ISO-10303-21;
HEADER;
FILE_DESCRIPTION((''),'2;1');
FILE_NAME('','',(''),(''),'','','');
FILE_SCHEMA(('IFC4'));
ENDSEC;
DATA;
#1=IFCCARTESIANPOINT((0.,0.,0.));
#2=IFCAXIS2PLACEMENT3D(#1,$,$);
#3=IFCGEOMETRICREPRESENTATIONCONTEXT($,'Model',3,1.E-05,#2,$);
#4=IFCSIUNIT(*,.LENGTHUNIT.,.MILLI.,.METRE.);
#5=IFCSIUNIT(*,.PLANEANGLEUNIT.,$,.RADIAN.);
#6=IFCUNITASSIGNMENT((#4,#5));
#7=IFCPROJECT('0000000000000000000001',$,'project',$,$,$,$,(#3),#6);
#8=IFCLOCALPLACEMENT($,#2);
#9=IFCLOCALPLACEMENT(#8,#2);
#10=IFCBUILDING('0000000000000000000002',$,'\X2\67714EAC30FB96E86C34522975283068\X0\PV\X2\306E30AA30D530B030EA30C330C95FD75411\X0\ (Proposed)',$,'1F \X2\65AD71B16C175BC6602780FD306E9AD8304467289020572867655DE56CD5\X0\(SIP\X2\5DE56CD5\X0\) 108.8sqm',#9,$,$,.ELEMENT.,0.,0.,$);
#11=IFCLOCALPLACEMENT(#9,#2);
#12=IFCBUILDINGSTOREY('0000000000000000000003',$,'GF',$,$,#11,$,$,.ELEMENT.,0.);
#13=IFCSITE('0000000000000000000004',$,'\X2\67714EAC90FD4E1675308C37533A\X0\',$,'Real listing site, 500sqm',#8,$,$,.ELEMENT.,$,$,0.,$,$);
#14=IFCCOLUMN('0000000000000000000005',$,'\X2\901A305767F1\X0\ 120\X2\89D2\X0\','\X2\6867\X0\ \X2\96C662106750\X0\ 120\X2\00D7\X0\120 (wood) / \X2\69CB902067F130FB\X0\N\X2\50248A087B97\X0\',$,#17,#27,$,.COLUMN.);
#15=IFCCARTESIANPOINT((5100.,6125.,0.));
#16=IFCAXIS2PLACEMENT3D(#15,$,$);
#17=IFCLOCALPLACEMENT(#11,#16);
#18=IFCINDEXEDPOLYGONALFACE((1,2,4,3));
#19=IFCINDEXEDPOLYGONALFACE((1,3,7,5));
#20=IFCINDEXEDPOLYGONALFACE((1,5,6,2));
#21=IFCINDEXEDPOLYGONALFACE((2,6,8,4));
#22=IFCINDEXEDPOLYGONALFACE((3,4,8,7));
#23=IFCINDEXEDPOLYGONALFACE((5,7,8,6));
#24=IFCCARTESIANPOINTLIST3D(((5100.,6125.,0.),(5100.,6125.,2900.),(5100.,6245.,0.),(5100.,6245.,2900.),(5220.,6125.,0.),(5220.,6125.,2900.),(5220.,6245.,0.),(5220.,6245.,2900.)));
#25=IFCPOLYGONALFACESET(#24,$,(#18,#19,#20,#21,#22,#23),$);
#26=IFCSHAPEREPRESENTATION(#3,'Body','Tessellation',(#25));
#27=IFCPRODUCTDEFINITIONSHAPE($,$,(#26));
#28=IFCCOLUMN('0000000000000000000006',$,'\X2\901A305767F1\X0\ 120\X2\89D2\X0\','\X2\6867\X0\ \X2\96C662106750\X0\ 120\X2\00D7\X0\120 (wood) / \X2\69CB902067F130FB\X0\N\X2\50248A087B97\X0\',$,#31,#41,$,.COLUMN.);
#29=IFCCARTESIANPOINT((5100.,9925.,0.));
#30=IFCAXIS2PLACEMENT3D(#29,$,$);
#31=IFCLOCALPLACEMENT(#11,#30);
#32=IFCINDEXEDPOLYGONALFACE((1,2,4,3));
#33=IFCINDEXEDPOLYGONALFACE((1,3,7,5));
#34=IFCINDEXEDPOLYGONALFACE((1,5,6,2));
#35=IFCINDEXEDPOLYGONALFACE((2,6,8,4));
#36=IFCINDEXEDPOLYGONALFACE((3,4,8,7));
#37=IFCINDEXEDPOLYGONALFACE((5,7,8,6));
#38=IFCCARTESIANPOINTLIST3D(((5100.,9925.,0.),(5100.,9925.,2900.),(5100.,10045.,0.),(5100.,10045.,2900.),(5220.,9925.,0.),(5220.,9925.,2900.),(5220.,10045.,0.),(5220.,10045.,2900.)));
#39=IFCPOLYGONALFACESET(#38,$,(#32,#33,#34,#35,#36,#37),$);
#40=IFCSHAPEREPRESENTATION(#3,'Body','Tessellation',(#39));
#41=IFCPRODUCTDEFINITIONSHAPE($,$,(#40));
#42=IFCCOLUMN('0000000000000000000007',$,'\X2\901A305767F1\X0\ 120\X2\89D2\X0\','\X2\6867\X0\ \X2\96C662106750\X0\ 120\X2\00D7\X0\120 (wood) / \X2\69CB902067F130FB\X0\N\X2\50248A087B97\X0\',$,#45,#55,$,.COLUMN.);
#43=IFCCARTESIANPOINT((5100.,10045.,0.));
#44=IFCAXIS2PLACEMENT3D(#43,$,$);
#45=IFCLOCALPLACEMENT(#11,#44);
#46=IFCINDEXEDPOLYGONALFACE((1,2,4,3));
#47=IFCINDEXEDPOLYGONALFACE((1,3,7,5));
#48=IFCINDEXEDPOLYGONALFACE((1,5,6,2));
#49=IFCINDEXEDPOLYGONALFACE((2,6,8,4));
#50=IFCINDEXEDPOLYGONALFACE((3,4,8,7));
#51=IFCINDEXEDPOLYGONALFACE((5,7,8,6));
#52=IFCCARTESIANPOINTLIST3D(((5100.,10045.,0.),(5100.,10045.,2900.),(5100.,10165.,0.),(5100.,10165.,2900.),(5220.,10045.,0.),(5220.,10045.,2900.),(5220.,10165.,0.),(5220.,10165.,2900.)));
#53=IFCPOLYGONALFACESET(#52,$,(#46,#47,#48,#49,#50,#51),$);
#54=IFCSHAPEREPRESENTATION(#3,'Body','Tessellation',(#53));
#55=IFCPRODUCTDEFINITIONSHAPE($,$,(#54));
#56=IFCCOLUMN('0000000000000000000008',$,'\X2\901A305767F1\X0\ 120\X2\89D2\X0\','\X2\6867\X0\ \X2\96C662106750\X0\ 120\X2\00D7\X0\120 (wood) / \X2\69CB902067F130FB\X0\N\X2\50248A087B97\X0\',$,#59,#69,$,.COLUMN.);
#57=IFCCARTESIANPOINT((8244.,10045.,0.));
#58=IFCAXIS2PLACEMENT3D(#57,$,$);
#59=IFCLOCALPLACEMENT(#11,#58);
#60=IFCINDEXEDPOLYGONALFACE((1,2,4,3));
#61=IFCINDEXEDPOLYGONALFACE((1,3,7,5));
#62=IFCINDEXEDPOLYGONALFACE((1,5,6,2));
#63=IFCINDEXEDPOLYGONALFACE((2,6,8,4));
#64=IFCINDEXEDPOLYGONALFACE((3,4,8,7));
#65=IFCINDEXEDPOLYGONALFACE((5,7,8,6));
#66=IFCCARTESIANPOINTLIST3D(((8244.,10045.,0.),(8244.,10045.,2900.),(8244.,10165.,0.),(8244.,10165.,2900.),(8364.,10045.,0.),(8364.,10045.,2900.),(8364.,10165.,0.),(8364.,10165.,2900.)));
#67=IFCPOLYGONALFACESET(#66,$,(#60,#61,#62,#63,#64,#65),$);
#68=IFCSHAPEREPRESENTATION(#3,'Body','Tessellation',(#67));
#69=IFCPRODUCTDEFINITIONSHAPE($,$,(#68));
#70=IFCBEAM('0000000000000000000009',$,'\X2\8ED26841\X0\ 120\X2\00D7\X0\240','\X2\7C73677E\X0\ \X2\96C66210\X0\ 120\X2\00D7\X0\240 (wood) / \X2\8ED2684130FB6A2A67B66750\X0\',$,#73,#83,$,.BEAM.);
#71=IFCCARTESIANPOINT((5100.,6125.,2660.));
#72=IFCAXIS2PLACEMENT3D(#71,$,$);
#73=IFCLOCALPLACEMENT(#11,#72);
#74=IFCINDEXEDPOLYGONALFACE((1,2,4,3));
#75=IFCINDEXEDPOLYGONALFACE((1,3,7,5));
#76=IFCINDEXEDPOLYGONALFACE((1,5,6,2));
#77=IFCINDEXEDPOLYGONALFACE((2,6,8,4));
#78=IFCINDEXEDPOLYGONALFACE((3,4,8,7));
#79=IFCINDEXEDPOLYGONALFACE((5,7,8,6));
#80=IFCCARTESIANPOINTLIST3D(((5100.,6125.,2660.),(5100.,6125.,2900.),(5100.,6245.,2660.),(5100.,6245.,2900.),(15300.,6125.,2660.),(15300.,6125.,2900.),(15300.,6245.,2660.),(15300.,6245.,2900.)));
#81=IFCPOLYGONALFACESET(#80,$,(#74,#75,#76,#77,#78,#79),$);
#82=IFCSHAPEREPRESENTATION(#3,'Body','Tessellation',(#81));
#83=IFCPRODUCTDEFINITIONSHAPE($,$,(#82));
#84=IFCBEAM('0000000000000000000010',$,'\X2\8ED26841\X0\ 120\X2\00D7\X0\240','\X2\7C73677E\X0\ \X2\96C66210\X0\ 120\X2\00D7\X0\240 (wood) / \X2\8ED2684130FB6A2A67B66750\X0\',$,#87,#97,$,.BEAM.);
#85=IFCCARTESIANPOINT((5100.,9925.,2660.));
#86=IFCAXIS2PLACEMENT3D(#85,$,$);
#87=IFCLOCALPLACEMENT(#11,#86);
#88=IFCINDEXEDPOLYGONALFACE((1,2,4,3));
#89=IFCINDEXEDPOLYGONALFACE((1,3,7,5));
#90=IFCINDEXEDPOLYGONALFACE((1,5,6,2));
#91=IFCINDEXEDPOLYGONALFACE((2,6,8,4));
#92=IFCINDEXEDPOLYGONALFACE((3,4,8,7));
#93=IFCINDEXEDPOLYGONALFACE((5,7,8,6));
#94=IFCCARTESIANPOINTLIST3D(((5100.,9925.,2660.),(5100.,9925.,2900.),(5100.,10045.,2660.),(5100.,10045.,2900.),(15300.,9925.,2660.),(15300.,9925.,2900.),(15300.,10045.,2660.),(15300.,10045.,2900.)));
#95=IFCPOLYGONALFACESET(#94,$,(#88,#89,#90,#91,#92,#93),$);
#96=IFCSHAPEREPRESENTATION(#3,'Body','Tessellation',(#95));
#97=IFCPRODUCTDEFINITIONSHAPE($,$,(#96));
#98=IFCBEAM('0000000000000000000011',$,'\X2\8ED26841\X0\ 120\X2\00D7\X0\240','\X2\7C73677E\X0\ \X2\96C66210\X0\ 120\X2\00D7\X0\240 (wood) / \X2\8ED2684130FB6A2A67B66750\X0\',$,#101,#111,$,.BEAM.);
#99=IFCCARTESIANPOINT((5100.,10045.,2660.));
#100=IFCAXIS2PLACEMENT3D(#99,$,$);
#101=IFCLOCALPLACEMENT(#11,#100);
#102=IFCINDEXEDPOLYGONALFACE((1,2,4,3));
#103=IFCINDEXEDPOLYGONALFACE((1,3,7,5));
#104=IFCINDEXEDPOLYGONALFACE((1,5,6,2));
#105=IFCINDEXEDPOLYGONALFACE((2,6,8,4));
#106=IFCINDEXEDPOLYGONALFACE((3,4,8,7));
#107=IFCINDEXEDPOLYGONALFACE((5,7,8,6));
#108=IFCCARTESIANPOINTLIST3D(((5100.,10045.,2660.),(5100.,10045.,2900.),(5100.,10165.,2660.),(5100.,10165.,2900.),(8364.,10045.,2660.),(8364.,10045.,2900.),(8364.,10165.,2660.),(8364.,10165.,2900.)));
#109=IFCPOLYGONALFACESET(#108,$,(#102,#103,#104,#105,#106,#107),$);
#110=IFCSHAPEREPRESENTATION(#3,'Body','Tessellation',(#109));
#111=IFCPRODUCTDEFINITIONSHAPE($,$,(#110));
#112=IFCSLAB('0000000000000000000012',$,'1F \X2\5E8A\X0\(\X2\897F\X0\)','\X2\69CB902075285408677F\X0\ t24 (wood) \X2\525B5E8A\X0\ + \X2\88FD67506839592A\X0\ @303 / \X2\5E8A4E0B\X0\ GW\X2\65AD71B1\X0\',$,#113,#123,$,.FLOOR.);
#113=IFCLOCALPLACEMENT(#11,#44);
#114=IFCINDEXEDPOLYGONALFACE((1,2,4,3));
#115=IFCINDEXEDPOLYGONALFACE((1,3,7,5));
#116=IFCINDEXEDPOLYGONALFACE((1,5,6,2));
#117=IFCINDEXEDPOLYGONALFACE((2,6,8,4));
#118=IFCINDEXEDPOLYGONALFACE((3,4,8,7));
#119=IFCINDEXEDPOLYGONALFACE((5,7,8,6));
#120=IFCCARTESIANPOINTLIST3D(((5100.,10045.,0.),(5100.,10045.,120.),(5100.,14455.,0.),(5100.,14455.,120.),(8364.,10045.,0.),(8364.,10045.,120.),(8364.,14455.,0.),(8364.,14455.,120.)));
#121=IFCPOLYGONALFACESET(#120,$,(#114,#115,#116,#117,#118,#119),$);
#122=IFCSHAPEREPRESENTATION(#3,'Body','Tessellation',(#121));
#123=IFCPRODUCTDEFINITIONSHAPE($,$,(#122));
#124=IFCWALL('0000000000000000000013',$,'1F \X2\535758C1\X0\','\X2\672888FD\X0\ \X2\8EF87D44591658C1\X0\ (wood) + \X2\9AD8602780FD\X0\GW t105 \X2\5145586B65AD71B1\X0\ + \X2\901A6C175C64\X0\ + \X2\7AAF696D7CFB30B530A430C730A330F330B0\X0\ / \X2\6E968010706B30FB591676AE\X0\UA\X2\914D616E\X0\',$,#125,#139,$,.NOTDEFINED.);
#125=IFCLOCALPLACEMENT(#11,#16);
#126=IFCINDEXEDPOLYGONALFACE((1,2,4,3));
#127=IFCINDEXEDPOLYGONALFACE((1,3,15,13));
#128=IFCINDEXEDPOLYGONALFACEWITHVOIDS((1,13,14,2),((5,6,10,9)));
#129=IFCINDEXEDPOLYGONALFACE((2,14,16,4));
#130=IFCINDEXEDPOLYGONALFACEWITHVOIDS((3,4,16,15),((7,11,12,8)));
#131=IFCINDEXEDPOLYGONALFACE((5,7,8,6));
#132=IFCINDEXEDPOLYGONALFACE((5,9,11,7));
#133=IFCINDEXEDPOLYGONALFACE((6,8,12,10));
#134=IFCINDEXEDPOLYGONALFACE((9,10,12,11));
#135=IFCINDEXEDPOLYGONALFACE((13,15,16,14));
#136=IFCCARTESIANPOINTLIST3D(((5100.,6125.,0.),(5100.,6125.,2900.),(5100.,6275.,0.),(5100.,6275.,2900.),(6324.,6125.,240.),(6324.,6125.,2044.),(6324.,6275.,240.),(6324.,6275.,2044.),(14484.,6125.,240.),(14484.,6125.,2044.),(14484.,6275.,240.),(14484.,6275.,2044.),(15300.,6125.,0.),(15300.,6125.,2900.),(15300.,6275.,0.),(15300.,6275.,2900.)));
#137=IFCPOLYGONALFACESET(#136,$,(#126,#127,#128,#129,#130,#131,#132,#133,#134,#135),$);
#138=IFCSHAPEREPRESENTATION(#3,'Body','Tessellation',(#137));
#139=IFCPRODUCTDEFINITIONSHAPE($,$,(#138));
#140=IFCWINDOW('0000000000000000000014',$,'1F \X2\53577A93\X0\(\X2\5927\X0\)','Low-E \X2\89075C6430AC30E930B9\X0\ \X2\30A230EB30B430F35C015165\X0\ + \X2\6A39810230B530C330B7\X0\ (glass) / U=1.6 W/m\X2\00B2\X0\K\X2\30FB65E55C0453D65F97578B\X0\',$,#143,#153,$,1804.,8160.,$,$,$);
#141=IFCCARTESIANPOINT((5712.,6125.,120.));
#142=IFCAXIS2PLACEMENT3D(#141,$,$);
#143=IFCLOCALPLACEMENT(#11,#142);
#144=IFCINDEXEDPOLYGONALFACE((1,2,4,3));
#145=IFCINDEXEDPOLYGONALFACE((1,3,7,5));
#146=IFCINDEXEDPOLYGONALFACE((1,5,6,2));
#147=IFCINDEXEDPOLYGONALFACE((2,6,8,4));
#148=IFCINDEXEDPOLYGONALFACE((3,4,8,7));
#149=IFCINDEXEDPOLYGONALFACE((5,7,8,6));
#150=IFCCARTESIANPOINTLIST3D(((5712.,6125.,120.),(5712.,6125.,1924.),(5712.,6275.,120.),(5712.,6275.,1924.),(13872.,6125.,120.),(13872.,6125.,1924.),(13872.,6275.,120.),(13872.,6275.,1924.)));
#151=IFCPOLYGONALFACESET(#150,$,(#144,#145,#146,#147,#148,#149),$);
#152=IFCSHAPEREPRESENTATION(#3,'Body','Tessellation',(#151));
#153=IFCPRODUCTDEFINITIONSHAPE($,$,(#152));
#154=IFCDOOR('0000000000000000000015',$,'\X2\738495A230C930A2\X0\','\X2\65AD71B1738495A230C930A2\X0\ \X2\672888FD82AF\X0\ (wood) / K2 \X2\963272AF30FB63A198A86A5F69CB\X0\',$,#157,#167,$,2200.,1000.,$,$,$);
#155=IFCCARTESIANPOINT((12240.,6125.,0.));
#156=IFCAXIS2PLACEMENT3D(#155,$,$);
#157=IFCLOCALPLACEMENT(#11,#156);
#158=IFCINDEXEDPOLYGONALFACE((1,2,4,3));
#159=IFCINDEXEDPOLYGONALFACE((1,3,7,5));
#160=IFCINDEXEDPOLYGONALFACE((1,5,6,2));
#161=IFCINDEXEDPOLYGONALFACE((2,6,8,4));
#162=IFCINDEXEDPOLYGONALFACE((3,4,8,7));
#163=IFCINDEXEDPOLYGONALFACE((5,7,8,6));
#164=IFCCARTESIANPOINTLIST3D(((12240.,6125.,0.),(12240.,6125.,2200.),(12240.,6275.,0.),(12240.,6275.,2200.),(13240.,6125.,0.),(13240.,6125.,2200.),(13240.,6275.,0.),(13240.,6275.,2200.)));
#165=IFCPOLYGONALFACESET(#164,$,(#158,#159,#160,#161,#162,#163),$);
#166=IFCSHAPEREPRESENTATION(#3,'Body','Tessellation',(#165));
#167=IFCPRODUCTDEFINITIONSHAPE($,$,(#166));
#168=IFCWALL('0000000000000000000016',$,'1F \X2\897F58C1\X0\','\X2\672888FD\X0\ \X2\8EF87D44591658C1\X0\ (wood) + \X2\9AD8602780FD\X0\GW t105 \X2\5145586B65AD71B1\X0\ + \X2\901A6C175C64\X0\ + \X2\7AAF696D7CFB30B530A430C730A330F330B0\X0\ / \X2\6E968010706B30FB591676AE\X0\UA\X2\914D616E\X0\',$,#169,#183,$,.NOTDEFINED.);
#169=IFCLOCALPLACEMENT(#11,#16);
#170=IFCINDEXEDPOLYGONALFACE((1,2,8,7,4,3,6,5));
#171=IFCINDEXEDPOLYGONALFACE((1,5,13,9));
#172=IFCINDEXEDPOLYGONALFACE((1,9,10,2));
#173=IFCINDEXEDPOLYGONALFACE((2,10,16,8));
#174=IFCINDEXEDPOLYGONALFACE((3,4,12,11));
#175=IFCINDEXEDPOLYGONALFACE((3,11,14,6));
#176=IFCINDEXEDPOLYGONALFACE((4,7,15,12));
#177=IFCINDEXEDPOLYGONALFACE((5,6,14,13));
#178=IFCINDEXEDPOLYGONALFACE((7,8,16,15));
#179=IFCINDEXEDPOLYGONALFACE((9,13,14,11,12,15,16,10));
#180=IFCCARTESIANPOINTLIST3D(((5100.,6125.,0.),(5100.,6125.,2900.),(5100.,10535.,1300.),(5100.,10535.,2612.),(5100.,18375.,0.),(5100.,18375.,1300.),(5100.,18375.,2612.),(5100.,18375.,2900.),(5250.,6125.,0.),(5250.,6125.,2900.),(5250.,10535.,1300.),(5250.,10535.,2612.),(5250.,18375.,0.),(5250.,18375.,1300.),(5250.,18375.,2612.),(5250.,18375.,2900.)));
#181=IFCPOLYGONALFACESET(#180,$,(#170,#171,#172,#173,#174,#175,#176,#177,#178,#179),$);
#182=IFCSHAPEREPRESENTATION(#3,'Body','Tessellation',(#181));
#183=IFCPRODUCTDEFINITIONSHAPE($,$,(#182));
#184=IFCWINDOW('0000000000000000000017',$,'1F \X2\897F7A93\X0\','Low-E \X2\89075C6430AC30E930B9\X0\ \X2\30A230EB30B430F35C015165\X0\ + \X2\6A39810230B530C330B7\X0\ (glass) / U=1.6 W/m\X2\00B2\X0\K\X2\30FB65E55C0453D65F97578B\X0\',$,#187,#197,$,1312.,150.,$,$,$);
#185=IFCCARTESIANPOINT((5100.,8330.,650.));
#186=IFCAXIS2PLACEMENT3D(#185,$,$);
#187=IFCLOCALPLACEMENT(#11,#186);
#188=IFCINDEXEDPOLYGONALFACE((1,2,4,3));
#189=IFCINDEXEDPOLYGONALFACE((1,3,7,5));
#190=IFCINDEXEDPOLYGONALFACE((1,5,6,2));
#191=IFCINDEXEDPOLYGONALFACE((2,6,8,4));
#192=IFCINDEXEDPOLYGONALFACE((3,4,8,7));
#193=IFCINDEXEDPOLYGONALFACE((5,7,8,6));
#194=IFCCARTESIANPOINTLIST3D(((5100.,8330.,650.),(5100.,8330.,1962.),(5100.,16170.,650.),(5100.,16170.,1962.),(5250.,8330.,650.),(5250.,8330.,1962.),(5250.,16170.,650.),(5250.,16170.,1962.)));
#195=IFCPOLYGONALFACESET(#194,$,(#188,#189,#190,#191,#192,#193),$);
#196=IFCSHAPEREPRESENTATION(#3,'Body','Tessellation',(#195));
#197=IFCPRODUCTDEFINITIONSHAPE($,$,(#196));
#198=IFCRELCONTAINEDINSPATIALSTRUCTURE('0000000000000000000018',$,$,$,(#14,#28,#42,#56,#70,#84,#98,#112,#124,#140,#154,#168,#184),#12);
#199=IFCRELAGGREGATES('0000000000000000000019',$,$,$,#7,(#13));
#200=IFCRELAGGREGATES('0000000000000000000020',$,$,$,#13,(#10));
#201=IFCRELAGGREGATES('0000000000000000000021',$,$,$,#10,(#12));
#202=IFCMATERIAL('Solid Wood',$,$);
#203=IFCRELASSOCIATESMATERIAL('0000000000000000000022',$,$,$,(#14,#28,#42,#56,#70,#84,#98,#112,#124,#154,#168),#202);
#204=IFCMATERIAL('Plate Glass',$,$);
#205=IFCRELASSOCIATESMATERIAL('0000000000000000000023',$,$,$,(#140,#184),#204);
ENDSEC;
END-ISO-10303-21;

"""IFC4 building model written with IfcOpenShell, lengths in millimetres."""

from ifc_helpers import new_model, si_unit, frame, frame_2d, origin, place, context, project, spatial, rectangle, extrude, material, element, fill, save


model = new_model("IFC4")

# Units and contexts
model_context = context("Model", 3, precision=1e-05, world=origin())
ifc_project = project(units=[si_unit("LENGTHUNIT", "METRE", prefix="MILLI"), si_unit("PLANEANGLEUNIT", "RADIAN")], contexts=[model_context])

# Site, building, storey
site_placement = place(None, origin())
site = spatial("IfcSite", under=ifc_project, at=site_placement, Name="東京都世田谷区", ObjectType="Real listing site, 500sqm", CompositionType="ELEMENT", RefElevation=0.0)
building_placement = place(site_placement, origin())
building = spatial("IfcBuilding", under=site, at=building_placement, Name="東京・雨水利用とPVのオフグリッド志向 (Proposed)", ObjectType="1F 断熱気密性能の高い木造在来工法(SIP工法) 108.8sqm", CompositionType="ELEMENT", ElevationOfRefHeight=0.0, ElevationOfTerrain=0.0)
storey_placement = place(building_placement, origin())
storey = spatial("IfcBuildingStorey", under=building, at=storey_placement, Name="GF", CompositionType="ELEMENT", Elevation=0.0)

# Columns
ifc_material_1 = material(Name="Solid Wood")
column_1_placement = place(storey_placement, frame((5100.0, 6125.0, 0.0)))
element("IfcColumn", 1, at=column_1_placement, inside=storey, material=ifc_material_1, Name="通し柱 120角", Description="桧 集成材 120×120 (wood) / 構造柱・N値計算", PredefinedType="COLUMN", context=model_context, shape_type="SweptSolid", body=[
    extrude(rectangle(XDim=120.0, YDim=120.0, at=frame_2d((60.0, 60.0))), frame((5100.0, 6125.0, 0.0)), (0.0, 0.0, 1.0), 2900.0),
])
column_2_placement = place(storey_placement, frame((5100.0, 9925.0, 0.0)))
element("IfcColumn", 2, at=column_2_placement, inside=storey, material=ifc_material_1, Name="通し柱 120角", Description="桧 集成材 120×120 (wood) / 構造柱・N値計算", PredefinedType="COLUMN", context=model_context, shape_type="SweptSolid", body=[
    extrude(rectangle(XDim=120.0, YDim=120.0, at=frame_2d((60.0, 60.0))), frame((5100.0, 9925.0, 0.0)), (0.0, 0.0, 1.0), 2900.0),
])
column_3_placement = place(storey_placement, frame((5100.0, 10045.0, 0.0)))
element("IfcColumn", 3, at=column_3_placement, inside=storey, material=ifc_material_1, Name="通し柱 120角", Description="桧 集成材 120×120 (wood) / 構造柱・N値計算", PredefinedType="COLUMN", context=model_context, shape_type="SweptSolid", body=[
    extrude(rectangle(XDim=120.0, YDim=120.0, at=frame_2d((60.0, 60.0))), frame((5100.0, 10045.0, 0.0)), (0.0, 0.0, 1.0), 2900.0),
])
column_4_placement = place(storey_placement, frame((8244.0, 10045.0, 0.0)))
element("IfcColumn", 4, at=column_4_placement, inside=storey, material=ifc_material_1, Name="通し柱 120角", Description="桧 集成材 120×120 (wood) / 構造柱・N値計算", PredefinedType="COLUMN", context=model_context, shape_type="SweptSolid", body=[
    extrude(rectangle(XDim=120.0, YDim=120.0, at=frame_2d((60.0, 60.0))), frame((8244.0, 10045.0, 0.0)), (0.0, 0.0, 1.0), 2900.0),
])

# Beams
beam_1_placement = place(storey_placement, frame((5100.0, 6125.0, 2660.0)))
element("IfcBeam", 5, at=beam_1_placement, inside=storey, material=ifc_material_1, Name="軒桁 120×240", Description="米松 集成 120×240 (wood) / 軒桁・横架材", PredefinedType="BEAM", context=model_context, shape_type="SweptSolid", body=[
    extrude(rectangle(XDim=10200.0, YDim=120.0, at=frame_2d((5100.0, 60.0))), frame((5100.0, 6125.0, 2660.0)), (0.0, 0.0, 1.0), 240.0),
])
beam_2_placement = place(storey_placement, frame((5100.0, 9925.0, 2660.0)))
element("IfcBeam", 6, at=beam_2_placement, inside=storey, material=ifc_material_1, Name="軒桁 120×240", Description="米松 集成 120×240 (wood) / 軒桁・横架材", PredefinedType="BEAM", context=model_context, shape_type="SweptSolid", body=[
    extrude(rectangle(XDim=10200.0, YDim=120.0, at=frame_2d((5100.0, 60.0))), frame((5100.0, 9925.0, 2660.0)), (0.0, 0.0, 1.0), 240.0),
])
beam_3_placement = place(storey_placement, frame((5100.0, 10045.0, 2660.0)))
element("IfcBeam", 7, at=beam_3_placement, inside=storey, material=ifc_material_1, Name="軒桁 120×240", Description="米松 集成 120×240 (wood) / 軒桁・横架材", PredefinedType="BEAM", context=model_context, shape_type="SweptSolid", body=[
    extrude(rectangle(XDim=3264.0, YDim=120.0, at=frame_2d((1632.0, 60.0))), frame((5100.0, 10045.0, 2660.0)), (0.0, 0.0, 1.0), 240.0),
])

# Slab
slab_1_placement = place(storey_placement, frame((5100.0, 10045.0, 0.0)))
element("IfcSlab", 8, at=slab_1_placement, inside=storey, material=ifc_material_1, Name="1F 床(西)", Description="構造用合板 t24 (wood) 剛床 + 製材根太 @303 / 床下 GW断熱", PredefinedType="FLOOR", context=model_context, shape_type="SweptSolid", body=[
    extrude(rectangle(XDim=3264.0, YDim=4410.0, at=frame_2d((1632.0, 2205.0))), frame((5100.0, 10045.0, 0.0)), (0.0, 0.0, 1.0), 120.0),
])

# Wall, openings, window, door
wall_1_placement = place(storey_placement, frame((5100.0, 6125.0, 0.0)))
wall_1 = element("IfcWall", 9, at=wall_1_placement, inside=storey, material=ifc_material_1, Name="1F 南壁", Description="木製 軸組外壁 (wood) + 高性能GW t105 充填断熱 + 通気層 + 窯業系サイディング / 準耐火・外皮UA配慮", PredefinedType="NOTDEFINED", context=model_context, shape_type="SweptSolid", body=[
    extrude(rectangle(XDim=10200.0, YDim=150.0, at=frame_2d((5100.0, 75.0))), frame((5100.0, 6125.0, 0.0)), (0.0, 0.0, 1.0), 2900.0),
])
opening_1_placement = place(storey_placement, frame((5712.0, 6125.0, 120.0)))
opening_1 = element("IfcOpeningElement", 10, at=opening_1_placement, cuts=wall_1, PredefinedType="NOTDEFINED", context=model_context, shape_type="SweptSolid", body=[
    extrude(rectangle(XDim=8160.0, YDim=150.0, at=frame_2d((4080.0, 75.0))), frame((5712.0, 6125.0, 120.0)), (0.0, 0.0, 1.0), 1804.0),
])
opening_2_placement = place(storey_placement, frame((12240.0, 6125.0, 0.0)))
opening_2 = element("IfcOpeningElement", 11, at=opening_2_placement, cuts=wall_1, PredefinedType="NOTDEFINED", context=model_context, shape_type="SweptSolid", body=[
    extrude(rectangle(XDim=1000.0, YDim=150.0, at=frame_2d((500.0, 75.0))), frame((12240.0, 6125.0, 0.0)), (0.0, 0.0, 1.0), 2200.0),
])
ifc_material_2 = material(Name="Plate Glass")
window_1_placement = place(storey_placement, frame((5712.0, 6125.0, 120.0)))
window_1 = element("IfcWindow", 12, at=window_1_placement, inside=storey, material=ifc_material_2, Name="1F 南窓(大)", Description="Low-E 複層ガラス アルゴン封入 + 樹脂サッシ (glass) / U=1.6 W/m²K・日射取得型", OverallHeight=1804.0, OverallWidth=8160.0, context=model_context, shape_type="SweptSolid", body=[
    extrude(rectangle(XDim=8160.0, YDim=150.0, at=frame_2d((4080.0, 75.0))), frame((5712.0, 6125.0, 120.0)), (0.0, 0.0, 1.0), 1804.0),
])
fill(opening_1, window_1)
door_placement = place(storey_placement, frame((12240.0, 6125.0, 0.0)))
door = element("IfcDoor", 13, at=door_placement, inside=storey, material=ifc_material_1, Name="玄関ドア", Description="断熱玄関ドア 木製芯 (wood) / K2 防犯・採風機構", OverallHeight=2200.0, OverallWidth=1000.0, context=model_context, shape_type="SweptSolid", body=[
    extrude(rectangle(XDim=1000.0, YDim=150.0, at=frame_2d((500.0, 75.0))), frame((12240.0, 6125.0, 0.0)), (0.0, 0.0, 1.0), 2200.0),
])
fill(opening_2, door)

# Wall, opening, window
wall_2_placement = place(storey_placement, frame((5100.0, 6125.0, 0.0)))
wall_2 = element("IfcWall", 14, at=wall_2_placement, inside=storey, material=ifc_material_1, Name="1F 西壁", Description="木製 軸組外壁 (wood) + 高性能GW t105 充填断熱 + 通気層 + 窯業系サイディング / 準耐火・外皮UA配慮", PredefinedType="NOTDEFINED", context=model_context, shape_type="SweptSolid", body=[
    extrude(rectangle(XDim=150.0, YDim=12250.0, at=frame_2d((75.0, 6125.0))), frame((5100.0, 6125.0, 0.0)), (0.0, 0.0, 1.0), 2900.0),
])
opening_3_placement = place(storey_placement, frame((5100.0, 8330.0, 650.0)))
opening_3 = element("IfcOpeningElement", 15, at=opening_3_placement, cuts=wall_2, PredefinedType="NOTDEFINED", context=model_context, shape_type="SweptSolid", body=[
    extrude(rectangle(XDim=150.0, YDim=7840.0, at=frame_2d((75.0, 3920.0))), frame((5100.0, 8330.0, 650.0)), (0.0, 0.0, 1.0), 1312.0),
])
window_2_placement = place(storey_placement, frame((5100.0, 8330.0, 650.0)))
window_2 = element("IfcWindow", 16, at=window_2_placement, inside=storey, material=ifc_material_2, Name="1F 西窓", Description="Low-E 複層ガラス アルゴン封入 + 樹脂サッシ (glass) / U=1.6 W/m²K・日射取得型", OverallHeight=1312.0, OverallWidth=150.0, context=model_context, shape_type="SweptSolid", body=[
    extrude(rectangle(XDim=150.0, YDim=7840.0, at=frame_2d((75.0, 3920.0))), frame((5100.0, 8330.0, 650.0)), (0.0, 0.0, 1.0), 1312.0),
])
fill(opening_3, window_2)

save(model, "model.ifc")
